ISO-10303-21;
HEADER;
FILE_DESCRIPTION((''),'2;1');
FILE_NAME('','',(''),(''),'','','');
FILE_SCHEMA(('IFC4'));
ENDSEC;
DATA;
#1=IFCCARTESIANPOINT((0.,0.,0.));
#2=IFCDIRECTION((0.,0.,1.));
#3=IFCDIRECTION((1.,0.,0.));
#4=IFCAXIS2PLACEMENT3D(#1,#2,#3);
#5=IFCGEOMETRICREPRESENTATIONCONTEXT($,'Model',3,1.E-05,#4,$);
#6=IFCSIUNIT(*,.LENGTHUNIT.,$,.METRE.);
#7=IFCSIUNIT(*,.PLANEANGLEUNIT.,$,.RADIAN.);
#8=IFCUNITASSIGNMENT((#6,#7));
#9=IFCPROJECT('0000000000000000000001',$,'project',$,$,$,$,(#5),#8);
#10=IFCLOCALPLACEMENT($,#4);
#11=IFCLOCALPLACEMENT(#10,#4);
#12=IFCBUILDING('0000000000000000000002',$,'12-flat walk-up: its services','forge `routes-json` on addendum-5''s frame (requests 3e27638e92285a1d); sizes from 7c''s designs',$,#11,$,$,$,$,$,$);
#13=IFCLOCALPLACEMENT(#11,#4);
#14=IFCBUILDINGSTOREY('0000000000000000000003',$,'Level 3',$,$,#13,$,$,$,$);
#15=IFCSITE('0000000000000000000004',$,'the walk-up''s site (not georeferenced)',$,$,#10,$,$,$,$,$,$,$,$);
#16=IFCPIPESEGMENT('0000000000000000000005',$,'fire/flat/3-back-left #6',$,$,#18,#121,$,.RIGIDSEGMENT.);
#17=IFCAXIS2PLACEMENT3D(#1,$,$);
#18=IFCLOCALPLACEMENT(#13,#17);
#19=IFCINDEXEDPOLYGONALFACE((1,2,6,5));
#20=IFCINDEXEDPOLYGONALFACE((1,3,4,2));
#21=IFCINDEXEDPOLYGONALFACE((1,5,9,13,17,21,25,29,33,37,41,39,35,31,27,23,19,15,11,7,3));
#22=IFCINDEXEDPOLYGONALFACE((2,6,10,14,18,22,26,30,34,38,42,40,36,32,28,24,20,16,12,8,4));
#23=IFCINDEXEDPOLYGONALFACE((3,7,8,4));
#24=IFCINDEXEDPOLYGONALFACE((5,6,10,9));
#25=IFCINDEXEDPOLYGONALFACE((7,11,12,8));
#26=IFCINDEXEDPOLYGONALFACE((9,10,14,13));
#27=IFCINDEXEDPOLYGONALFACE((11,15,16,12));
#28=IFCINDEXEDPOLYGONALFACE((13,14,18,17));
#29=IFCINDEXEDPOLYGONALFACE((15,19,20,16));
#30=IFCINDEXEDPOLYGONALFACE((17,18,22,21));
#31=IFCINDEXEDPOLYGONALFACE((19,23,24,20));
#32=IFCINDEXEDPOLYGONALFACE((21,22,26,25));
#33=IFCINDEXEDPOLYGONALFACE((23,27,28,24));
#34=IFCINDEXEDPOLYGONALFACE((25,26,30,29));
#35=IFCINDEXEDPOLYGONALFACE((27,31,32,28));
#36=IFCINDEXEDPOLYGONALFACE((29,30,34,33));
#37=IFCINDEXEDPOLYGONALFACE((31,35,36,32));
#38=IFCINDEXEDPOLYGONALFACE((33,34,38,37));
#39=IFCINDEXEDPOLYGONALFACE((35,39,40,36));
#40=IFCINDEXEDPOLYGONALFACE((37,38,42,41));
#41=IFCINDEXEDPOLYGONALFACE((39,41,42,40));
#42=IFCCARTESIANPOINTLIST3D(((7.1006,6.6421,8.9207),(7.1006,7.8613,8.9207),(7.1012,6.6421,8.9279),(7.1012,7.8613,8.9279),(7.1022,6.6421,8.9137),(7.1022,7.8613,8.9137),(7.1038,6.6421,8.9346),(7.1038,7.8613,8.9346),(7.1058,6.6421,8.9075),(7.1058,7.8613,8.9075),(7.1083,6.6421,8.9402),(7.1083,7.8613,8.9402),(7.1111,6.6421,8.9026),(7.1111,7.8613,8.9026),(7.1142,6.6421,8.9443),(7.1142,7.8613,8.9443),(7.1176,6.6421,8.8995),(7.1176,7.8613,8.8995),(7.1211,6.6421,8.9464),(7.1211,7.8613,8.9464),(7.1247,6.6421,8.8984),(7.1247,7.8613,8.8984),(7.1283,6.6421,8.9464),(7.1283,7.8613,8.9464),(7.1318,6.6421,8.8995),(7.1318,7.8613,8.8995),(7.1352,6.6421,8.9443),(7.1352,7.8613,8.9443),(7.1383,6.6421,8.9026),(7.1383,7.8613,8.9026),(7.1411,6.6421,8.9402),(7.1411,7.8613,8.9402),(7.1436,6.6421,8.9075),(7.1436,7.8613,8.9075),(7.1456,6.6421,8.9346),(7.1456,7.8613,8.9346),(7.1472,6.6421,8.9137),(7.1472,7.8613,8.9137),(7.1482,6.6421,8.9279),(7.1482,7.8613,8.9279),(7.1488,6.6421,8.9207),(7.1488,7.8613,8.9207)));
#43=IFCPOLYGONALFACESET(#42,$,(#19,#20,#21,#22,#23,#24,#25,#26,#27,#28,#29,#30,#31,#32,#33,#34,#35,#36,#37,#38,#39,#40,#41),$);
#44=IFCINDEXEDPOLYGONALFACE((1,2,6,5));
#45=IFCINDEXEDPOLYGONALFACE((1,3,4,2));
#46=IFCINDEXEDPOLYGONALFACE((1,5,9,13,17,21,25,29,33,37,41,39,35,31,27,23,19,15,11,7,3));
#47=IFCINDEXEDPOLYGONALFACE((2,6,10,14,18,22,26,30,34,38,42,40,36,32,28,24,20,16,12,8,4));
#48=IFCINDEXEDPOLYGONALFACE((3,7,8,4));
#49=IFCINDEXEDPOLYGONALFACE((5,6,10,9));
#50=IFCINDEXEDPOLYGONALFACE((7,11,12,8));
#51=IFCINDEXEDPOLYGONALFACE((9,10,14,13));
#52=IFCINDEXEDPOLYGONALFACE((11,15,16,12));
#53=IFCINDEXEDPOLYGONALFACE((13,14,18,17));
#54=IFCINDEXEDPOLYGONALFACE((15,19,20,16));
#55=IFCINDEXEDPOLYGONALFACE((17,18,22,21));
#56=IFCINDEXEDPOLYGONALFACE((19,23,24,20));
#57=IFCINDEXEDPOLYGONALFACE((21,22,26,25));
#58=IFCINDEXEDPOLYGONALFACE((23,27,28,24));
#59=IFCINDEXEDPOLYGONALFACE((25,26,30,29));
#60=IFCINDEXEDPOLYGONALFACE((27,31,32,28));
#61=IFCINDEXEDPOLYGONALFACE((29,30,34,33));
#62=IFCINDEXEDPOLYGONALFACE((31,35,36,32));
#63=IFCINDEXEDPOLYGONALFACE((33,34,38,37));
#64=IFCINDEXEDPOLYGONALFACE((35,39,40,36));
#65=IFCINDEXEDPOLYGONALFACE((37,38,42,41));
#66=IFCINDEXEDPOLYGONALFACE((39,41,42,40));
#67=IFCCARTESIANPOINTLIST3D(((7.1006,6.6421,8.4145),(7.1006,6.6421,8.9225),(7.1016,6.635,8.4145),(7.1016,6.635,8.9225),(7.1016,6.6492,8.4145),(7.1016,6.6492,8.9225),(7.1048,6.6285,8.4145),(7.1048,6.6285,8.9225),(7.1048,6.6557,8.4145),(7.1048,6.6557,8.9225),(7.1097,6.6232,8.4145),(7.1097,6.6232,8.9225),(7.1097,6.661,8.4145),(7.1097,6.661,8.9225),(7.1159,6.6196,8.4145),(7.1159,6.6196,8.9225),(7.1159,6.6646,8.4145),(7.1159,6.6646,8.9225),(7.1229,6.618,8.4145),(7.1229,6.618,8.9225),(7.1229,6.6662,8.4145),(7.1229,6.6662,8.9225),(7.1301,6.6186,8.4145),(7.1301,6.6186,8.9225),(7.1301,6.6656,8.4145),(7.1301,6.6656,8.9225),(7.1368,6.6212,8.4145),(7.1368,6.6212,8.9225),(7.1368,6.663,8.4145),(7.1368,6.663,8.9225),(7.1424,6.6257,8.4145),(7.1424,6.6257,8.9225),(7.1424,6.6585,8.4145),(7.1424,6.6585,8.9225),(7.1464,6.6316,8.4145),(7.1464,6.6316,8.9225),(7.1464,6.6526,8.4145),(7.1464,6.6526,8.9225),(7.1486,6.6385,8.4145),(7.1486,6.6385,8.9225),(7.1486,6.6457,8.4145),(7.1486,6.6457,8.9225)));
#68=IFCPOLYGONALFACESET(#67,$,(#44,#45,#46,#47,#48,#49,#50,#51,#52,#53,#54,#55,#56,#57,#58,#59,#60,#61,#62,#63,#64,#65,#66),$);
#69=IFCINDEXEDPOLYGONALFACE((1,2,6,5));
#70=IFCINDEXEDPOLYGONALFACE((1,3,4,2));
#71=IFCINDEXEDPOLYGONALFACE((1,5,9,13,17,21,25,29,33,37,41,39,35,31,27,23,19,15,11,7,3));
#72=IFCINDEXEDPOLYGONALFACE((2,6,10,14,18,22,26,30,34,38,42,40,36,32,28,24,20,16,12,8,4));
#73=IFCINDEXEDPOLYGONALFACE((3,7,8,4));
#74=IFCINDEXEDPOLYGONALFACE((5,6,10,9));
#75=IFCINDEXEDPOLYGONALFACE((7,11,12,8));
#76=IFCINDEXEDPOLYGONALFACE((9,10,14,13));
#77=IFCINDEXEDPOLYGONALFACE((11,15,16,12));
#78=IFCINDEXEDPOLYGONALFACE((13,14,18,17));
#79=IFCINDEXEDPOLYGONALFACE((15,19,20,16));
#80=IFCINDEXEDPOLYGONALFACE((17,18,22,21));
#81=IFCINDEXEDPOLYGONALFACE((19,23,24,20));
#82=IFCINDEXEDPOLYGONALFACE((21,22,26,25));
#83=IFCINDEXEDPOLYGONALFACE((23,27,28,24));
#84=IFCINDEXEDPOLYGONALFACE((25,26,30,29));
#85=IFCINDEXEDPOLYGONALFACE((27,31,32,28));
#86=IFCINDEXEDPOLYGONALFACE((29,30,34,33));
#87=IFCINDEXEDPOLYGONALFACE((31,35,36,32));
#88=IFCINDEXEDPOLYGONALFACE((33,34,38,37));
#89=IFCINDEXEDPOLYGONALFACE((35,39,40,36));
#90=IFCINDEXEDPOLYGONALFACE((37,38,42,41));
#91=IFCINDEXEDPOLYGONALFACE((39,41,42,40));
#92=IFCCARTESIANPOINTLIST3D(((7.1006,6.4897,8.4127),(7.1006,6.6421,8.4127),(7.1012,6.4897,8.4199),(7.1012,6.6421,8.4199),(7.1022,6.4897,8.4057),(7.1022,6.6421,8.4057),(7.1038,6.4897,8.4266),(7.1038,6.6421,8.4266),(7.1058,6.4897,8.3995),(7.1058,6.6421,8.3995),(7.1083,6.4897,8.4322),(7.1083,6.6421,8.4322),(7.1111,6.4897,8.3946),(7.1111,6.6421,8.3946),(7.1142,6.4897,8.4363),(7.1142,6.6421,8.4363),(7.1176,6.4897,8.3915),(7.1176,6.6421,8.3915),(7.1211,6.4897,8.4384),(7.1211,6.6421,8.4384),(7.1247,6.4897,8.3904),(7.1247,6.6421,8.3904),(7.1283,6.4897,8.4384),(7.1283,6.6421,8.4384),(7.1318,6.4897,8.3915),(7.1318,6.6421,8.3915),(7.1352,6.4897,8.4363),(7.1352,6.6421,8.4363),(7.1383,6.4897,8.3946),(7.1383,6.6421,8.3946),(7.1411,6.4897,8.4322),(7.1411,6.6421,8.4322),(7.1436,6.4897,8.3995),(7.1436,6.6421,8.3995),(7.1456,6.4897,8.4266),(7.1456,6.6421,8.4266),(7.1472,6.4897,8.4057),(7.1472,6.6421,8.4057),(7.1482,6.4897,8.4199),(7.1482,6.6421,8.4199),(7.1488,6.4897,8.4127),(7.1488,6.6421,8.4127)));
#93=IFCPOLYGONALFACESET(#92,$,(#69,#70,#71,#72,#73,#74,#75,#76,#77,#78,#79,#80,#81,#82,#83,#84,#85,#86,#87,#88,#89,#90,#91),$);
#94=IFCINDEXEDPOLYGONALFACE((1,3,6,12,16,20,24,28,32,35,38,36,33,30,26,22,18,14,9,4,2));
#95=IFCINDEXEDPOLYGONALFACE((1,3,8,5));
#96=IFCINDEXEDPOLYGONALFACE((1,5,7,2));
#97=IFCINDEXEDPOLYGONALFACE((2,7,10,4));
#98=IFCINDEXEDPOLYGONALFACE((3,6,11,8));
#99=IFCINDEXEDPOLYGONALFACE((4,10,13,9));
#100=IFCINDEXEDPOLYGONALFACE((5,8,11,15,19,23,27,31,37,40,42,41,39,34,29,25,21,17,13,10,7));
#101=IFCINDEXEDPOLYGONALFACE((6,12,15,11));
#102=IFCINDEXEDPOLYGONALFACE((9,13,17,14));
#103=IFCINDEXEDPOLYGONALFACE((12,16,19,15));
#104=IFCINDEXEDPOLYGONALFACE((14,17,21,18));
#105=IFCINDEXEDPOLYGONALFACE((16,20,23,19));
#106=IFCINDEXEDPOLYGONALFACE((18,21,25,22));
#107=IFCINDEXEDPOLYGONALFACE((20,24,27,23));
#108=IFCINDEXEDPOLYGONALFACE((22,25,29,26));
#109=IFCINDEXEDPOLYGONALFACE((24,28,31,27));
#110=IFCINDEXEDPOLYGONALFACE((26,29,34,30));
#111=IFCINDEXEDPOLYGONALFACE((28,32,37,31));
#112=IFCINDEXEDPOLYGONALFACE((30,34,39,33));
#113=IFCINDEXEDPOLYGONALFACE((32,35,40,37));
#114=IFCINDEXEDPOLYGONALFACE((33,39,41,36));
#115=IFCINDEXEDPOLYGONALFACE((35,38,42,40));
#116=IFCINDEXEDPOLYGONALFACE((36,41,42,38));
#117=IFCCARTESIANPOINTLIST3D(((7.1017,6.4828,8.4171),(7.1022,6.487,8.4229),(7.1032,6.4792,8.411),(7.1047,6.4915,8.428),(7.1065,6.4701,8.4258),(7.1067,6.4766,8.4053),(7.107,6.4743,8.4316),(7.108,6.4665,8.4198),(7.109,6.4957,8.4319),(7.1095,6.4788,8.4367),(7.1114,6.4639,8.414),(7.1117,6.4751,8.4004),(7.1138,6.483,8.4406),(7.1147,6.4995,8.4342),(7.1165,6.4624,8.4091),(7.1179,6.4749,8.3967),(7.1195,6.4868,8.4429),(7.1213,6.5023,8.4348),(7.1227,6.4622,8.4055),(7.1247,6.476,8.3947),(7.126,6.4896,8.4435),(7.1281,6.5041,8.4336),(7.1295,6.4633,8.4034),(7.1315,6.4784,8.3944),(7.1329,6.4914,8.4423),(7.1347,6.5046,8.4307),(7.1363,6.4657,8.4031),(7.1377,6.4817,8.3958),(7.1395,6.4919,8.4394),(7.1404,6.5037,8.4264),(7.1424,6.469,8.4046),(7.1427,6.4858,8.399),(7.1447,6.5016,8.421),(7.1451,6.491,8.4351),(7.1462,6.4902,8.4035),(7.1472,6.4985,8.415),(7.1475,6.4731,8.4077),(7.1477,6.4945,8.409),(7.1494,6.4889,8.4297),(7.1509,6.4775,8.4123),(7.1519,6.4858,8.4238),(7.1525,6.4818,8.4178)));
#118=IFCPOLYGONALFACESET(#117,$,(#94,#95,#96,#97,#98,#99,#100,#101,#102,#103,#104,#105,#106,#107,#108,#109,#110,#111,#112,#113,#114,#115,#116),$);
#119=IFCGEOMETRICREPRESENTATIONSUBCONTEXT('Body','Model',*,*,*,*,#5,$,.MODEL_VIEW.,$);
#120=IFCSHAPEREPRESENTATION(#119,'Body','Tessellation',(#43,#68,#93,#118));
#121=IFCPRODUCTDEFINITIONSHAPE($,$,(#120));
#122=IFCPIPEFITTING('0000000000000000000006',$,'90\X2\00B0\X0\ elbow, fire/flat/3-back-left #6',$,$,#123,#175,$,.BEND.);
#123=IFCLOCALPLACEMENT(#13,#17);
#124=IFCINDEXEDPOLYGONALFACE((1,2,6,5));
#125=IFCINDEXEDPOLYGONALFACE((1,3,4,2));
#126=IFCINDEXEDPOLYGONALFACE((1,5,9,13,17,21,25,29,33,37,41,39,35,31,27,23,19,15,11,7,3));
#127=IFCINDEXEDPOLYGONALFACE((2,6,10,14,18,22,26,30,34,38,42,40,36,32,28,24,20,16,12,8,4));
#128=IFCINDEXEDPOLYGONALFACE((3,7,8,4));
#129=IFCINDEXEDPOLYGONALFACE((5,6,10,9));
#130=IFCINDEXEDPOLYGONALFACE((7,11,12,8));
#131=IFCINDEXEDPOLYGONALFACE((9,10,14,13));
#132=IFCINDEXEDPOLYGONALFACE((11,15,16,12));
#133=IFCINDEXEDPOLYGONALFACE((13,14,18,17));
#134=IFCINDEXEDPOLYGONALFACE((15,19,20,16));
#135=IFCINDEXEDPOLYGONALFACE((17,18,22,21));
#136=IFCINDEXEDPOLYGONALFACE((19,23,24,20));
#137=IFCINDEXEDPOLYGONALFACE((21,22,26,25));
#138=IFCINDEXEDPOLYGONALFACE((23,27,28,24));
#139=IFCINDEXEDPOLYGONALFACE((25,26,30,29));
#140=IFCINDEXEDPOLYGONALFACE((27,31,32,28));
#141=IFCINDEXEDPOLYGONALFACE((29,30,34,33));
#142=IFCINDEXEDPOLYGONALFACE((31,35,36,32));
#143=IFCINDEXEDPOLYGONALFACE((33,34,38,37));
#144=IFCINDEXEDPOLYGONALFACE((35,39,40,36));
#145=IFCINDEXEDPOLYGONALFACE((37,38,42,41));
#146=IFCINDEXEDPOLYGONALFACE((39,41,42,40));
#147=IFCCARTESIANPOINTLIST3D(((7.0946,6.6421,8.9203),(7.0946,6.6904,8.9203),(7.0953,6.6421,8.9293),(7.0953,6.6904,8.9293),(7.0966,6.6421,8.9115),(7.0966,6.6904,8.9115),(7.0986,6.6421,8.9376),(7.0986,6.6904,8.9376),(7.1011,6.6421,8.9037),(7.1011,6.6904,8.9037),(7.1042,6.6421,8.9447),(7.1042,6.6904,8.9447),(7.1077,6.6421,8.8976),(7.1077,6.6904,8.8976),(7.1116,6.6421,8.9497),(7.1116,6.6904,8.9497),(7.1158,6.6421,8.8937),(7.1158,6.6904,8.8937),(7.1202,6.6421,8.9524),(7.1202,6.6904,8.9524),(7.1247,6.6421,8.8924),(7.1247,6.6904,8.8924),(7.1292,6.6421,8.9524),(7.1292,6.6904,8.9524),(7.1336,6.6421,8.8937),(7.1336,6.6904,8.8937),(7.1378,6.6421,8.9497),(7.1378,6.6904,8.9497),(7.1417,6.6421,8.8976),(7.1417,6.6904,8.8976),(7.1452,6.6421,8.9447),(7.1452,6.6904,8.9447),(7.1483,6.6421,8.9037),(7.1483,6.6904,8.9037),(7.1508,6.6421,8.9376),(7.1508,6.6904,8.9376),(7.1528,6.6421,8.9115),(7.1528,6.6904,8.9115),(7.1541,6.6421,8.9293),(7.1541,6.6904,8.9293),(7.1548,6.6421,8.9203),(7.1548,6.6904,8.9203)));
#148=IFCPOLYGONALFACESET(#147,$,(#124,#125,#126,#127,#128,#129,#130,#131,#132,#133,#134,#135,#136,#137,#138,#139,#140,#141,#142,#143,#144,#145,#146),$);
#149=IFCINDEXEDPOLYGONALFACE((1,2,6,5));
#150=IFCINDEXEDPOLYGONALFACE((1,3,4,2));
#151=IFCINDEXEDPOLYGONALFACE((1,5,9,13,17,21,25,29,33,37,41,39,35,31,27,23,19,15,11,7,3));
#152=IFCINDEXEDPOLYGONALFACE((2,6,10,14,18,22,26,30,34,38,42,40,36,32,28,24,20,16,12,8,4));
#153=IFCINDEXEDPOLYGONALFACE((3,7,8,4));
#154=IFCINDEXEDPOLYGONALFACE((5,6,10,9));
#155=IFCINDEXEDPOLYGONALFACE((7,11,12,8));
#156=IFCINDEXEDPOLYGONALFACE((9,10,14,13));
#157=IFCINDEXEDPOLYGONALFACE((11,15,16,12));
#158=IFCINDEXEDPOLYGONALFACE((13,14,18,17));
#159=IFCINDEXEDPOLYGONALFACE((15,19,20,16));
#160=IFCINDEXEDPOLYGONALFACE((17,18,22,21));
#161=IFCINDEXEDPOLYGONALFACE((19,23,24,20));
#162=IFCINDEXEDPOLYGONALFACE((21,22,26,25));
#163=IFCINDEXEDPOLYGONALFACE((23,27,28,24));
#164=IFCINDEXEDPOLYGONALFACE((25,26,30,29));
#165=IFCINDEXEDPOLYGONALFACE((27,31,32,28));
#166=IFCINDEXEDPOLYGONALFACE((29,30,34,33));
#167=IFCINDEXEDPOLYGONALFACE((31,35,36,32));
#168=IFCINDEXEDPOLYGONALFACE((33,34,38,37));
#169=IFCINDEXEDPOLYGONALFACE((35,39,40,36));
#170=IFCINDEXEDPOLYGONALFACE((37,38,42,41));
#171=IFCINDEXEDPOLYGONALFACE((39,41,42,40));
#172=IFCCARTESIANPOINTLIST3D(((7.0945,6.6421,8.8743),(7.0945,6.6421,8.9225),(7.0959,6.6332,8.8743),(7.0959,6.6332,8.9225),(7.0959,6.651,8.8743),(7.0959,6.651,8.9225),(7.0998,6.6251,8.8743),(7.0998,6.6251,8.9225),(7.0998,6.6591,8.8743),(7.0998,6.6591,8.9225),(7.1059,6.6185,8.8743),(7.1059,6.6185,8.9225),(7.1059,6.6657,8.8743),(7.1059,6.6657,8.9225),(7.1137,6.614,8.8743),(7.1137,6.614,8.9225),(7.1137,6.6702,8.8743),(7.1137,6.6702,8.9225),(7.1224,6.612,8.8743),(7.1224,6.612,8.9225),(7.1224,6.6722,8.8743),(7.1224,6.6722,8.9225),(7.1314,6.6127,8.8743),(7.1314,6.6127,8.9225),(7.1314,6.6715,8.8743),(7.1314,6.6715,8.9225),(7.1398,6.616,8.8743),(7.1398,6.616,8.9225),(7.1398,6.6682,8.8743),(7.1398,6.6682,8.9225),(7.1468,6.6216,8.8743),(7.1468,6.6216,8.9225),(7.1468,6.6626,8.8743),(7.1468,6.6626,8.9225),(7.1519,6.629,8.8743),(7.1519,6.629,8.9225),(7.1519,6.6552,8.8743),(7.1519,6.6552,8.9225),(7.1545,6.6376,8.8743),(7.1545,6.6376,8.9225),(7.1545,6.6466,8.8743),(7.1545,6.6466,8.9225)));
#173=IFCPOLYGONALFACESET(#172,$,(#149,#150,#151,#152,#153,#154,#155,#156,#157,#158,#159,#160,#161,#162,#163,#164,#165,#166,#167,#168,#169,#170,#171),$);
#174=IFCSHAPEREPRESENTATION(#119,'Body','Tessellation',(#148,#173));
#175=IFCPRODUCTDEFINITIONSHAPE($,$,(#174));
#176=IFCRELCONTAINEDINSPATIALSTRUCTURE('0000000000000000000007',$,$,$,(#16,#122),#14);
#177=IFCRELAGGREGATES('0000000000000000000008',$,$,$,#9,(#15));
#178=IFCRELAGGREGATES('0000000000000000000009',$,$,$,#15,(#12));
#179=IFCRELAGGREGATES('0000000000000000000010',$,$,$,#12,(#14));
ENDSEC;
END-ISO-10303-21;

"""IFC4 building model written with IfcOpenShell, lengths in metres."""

from ifc_helpers import new_model, entity, si_unit, frame, origin_with_axes, place, context, subcontext, project, spatial, element, save


model = new_model("IFC4")

# Units and contexts
model_context = context("Model", 3, precision=1e-05, world=origin_with_axes())
body_context = subcontext(model_context, "Body", "Model", "MODEL_VIEW")
ifc_project = project(units=[si_unit("LENGTHUNIT", "METRE"), si_unit("PLANEANGLEUNIT", "RADIAN")], contexts=[model_context])

# Site, building, storey
site_placement = place(None, origin_with_axes())
site = spatial("IfcSite", under=ifc_project, at=site_placement, Name="the walk-up's site (not georeferenced)")
building_placement = place(site_placement, origin_with_axes())
building = spatial("IfcBuilding", under=site, at=building_placement, Name="12-flat walk-up: its services", Description="forge `routes-json` on addendum-5's frame (requests 3e27638e92285a1d); sizes from 7c's designs")
storey_placement = place(building_placement, origin_with_axes())
storey = spatial("IfcBuildingStorey", under=building, at=storey_placement, Name="Level 3")

# Pipe segment
pipe_segment_1_placement = place(storey_placement, frame((7.1247, 7.8613, 8.9225), z_axis=(0.0, 0.0, 1.0), x_axis=(1.0, 0.0, 0.0)))
element("IfcPipeSegment", 1, at=pipe_segment_1_placement, inside=storey, Name="fire/flat/3-back-left #6", PredefinedType="RIGIDSEGMENT", context=body_context, shape_type="AdvancedSweptSolid", body=[
    entity("IfcSweptDiskSolid", entity("IfcPolyline", [entity("IfcCartesianPoint", [0.0, 0.0, 0.0]), entity("IfcCartesianPoint", [0.0, -1.2192, 0.0])]), 0.0241),
    entity("IfcSweptDiskSolid", entity("IfcPolyline", [entity("IfcCartesianPoint", [0.0, -1.2192, 0.0]), entity("IfcCartesianPoint", [0.0, -1.2192, -0.508])]), 0.0241),
    entity("IfcSweptDiskSolid", entity("IfcPolyline", [entity("IfcCartesianPoint", [0.0, -1.2192, -0.508]), entity("IfcCartesianPoint", [0.0, -1.3716, -0.508])]), 0.0241),
    entity("IfcSweptDiskSolid", entity("IfcPolyline", [entity("IfcCartesianPoint", [0.0, -1.3716, -0.508]), entity("IfcCartesianPoint", [0.0048, -1.3843, -0.4993])]), 0.0241),
])

# Pipe fitting
pipe_fitting_1_placement = place(storey_placement, frame((7.1247, 6.6904, 8.9225), z_axis=(0.0, 0.0, 1.0), x_axis=(1.0, 0.0, 0.0)))
element("IfcPipeFitting", 2, at=pipe_fitting_1_placement, inside=storey, Name="90° elbow, fire/flat/3-back-left #6", PredefinedType="BEND", context=body_context, shape_type="AdvancedSweptSolid", body=[
    entity("IfcSweptDiskSolid", entity("IfcPolyline", [entity("IfcCartesianPoint", [0.0, 0.0, 0.0]), entity("IfcCartesianPoint", [0.0, -0.0483, 0.0])]), 0.0302),
    entity("IfcSweptDiskSolid", entity("IfcPolyline", [entity("IfcCartesianPoint", [0.0, -0.0483, 0.0]), entity("IfcCartesianPoint", [0.0, -0.0483, -0.0483])]), 0.0302),
])

save(model, "model.ifc")
